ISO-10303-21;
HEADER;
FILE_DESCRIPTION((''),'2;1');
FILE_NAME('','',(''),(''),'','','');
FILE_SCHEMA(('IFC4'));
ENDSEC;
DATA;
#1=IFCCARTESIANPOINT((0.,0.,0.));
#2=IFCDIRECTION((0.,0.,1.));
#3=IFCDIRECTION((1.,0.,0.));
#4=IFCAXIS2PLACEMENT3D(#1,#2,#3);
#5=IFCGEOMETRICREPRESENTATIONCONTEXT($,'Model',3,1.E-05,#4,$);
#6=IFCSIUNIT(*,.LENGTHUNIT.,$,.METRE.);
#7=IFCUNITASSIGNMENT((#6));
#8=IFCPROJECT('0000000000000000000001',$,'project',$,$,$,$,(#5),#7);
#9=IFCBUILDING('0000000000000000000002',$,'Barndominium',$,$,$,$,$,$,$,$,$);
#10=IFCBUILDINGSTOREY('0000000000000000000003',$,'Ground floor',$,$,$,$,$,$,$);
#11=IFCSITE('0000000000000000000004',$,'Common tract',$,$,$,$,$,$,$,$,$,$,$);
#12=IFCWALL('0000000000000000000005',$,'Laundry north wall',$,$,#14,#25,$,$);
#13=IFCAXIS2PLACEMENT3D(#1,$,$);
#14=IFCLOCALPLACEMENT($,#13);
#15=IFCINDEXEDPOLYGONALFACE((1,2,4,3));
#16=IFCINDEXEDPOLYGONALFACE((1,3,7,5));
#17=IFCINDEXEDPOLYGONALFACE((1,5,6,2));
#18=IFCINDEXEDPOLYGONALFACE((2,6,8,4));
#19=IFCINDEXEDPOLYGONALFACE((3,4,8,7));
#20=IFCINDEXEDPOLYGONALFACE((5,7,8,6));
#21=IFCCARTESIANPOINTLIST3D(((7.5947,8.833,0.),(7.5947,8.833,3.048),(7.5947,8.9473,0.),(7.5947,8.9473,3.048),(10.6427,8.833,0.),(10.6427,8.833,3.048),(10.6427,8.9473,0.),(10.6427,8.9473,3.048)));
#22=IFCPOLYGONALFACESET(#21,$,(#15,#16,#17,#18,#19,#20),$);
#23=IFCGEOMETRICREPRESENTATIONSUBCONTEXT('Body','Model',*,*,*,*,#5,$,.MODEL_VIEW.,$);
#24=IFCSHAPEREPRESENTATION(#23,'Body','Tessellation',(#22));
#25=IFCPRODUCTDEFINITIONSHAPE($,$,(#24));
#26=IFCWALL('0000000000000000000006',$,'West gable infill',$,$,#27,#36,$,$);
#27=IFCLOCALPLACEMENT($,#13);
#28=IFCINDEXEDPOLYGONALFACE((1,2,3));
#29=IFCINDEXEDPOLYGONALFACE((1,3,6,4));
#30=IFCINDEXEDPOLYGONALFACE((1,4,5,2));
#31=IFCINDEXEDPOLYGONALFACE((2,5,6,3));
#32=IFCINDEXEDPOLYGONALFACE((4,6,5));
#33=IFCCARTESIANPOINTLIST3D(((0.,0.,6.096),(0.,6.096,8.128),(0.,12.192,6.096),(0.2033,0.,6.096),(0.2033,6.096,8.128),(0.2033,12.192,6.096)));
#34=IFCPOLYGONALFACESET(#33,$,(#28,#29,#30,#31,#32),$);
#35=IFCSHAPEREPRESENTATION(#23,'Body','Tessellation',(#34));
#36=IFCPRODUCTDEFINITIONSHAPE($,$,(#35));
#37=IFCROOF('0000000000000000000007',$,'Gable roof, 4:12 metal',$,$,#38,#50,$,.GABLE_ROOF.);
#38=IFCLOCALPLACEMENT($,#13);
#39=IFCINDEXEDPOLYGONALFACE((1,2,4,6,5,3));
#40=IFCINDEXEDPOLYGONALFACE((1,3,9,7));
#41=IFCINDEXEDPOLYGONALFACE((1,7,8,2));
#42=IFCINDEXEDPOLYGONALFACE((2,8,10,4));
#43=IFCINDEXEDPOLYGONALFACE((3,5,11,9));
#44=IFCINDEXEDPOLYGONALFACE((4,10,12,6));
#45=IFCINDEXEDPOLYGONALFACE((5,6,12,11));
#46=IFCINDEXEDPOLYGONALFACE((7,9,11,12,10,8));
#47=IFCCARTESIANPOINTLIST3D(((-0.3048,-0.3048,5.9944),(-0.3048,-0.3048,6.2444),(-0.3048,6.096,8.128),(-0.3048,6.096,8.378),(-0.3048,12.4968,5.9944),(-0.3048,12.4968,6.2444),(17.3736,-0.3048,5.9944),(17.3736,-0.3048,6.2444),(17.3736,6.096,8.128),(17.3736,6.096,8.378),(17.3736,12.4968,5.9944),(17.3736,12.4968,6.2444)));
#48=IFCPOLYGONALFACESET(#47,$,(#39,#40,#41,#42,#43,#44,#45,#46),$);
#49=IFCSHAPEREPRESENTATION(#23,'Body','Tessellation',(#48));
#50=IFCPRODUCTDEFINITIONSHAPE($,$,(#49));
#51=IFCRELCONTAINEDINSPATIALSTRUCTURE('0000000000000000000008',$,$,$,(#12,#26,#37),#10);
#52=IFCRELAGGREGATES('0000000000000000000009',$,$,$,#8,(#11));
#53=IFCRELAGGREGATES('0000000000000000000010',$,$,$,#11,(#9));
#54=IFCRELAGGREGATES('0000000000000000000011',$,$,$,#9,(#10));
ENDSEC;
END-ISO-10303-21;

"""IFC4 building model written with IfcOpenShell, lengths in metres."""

from ifc_helpers import new_model, si_unit, frame, origin_with_axes, place, context, subcontext, project, spatial, polyline, indexed_curve, outline, extrude, element, save


model = new_model("IFC4")

# Units and contexts
model_context = context("Model", 3, precision=1e-05, world=origin_with_axes())
body_context = subcontext(model_context, "Body", "Model", "MODEL_VIEW")
ifc_project = project(units=[si_unit("LENGTHUNIT", "METRE")], contexts=[model_context])

# Site, building, storey
site = spatial("IfcSite", under=ifc_project, Name="Common tract")
building = spatial("IfcBuilding", under=site, Name="Barndominium")
storey = spatial("IfcBuildingStorey", under=building, Name="Ground floor")

# Walls
for number, where, z_axis, x_axis, name in (
    (1, (7.5947, 8.833, 0.0), (0.0, 0.0, 1.0), (1.0, 0.0, 0.0), "Laundry north wall"),
):
    element("IfcWall", number, at=place(None, frame(where, z_axis=z_axis, x_axis=x_axis)), inside=storey, Name=name, context=body_context, shape_type="SweptSolid", body=[
        extrude(outline(indexed_curve([(0.0, 0.0), (0.0, 0.1143), (3.048, 0.1143), (3.048, 0.0), (0.0, 0.0)], self_intersect=False)), origin_with_axes(), (0.0, 0.0, 1.0), 3.048),
    ])
wall_1_placement = place(None, frame((0.0, 0.0, 0.0), z_axis=(1.0, 0.0, 0.0), x_axis=(0.0, 1.0, 0.0)))
element("IfcWall", 2, at=wall_1_placement, inside=storey, Name="West gable infill", context=body_context, shape_type="SweptSolid", body=[
    extrude(outline(polyline([(0.0, 6.096), (12.192, 6.096), (6.096, 8.128), (0.0, 6.096)])), origin_with_axes(), (0.0, 0.0, 1.0), 0.2033),
])

# Roof
roof_placement = place(None, frame((-0.3048, 0.0, 0.0), z_axis=(1.0, 0.0, 0.0), x_axis=(0.0, 1.0, 0.0)))
element("IfcRoof", 3, at=roof_placement, inside=storey, Name="Gable roof, 4:12 metal", PredefinedType="GABLE_ROOF", context=body_context, shape_type="SweptSolid", body=[
    extrude(outline(polyline([(-0.3048, 5.9944), (6.096, 8.128), (12.4968, 5.9944), (12.4968, 6.2444), (6.096, 8.378), (-0.3048, 6.2444), (-0.3048, 5.9944)])), origin_with_axes(), (0.0, 0.0, 1.0), 17.6784),
])

save(model, "model.ifc")
